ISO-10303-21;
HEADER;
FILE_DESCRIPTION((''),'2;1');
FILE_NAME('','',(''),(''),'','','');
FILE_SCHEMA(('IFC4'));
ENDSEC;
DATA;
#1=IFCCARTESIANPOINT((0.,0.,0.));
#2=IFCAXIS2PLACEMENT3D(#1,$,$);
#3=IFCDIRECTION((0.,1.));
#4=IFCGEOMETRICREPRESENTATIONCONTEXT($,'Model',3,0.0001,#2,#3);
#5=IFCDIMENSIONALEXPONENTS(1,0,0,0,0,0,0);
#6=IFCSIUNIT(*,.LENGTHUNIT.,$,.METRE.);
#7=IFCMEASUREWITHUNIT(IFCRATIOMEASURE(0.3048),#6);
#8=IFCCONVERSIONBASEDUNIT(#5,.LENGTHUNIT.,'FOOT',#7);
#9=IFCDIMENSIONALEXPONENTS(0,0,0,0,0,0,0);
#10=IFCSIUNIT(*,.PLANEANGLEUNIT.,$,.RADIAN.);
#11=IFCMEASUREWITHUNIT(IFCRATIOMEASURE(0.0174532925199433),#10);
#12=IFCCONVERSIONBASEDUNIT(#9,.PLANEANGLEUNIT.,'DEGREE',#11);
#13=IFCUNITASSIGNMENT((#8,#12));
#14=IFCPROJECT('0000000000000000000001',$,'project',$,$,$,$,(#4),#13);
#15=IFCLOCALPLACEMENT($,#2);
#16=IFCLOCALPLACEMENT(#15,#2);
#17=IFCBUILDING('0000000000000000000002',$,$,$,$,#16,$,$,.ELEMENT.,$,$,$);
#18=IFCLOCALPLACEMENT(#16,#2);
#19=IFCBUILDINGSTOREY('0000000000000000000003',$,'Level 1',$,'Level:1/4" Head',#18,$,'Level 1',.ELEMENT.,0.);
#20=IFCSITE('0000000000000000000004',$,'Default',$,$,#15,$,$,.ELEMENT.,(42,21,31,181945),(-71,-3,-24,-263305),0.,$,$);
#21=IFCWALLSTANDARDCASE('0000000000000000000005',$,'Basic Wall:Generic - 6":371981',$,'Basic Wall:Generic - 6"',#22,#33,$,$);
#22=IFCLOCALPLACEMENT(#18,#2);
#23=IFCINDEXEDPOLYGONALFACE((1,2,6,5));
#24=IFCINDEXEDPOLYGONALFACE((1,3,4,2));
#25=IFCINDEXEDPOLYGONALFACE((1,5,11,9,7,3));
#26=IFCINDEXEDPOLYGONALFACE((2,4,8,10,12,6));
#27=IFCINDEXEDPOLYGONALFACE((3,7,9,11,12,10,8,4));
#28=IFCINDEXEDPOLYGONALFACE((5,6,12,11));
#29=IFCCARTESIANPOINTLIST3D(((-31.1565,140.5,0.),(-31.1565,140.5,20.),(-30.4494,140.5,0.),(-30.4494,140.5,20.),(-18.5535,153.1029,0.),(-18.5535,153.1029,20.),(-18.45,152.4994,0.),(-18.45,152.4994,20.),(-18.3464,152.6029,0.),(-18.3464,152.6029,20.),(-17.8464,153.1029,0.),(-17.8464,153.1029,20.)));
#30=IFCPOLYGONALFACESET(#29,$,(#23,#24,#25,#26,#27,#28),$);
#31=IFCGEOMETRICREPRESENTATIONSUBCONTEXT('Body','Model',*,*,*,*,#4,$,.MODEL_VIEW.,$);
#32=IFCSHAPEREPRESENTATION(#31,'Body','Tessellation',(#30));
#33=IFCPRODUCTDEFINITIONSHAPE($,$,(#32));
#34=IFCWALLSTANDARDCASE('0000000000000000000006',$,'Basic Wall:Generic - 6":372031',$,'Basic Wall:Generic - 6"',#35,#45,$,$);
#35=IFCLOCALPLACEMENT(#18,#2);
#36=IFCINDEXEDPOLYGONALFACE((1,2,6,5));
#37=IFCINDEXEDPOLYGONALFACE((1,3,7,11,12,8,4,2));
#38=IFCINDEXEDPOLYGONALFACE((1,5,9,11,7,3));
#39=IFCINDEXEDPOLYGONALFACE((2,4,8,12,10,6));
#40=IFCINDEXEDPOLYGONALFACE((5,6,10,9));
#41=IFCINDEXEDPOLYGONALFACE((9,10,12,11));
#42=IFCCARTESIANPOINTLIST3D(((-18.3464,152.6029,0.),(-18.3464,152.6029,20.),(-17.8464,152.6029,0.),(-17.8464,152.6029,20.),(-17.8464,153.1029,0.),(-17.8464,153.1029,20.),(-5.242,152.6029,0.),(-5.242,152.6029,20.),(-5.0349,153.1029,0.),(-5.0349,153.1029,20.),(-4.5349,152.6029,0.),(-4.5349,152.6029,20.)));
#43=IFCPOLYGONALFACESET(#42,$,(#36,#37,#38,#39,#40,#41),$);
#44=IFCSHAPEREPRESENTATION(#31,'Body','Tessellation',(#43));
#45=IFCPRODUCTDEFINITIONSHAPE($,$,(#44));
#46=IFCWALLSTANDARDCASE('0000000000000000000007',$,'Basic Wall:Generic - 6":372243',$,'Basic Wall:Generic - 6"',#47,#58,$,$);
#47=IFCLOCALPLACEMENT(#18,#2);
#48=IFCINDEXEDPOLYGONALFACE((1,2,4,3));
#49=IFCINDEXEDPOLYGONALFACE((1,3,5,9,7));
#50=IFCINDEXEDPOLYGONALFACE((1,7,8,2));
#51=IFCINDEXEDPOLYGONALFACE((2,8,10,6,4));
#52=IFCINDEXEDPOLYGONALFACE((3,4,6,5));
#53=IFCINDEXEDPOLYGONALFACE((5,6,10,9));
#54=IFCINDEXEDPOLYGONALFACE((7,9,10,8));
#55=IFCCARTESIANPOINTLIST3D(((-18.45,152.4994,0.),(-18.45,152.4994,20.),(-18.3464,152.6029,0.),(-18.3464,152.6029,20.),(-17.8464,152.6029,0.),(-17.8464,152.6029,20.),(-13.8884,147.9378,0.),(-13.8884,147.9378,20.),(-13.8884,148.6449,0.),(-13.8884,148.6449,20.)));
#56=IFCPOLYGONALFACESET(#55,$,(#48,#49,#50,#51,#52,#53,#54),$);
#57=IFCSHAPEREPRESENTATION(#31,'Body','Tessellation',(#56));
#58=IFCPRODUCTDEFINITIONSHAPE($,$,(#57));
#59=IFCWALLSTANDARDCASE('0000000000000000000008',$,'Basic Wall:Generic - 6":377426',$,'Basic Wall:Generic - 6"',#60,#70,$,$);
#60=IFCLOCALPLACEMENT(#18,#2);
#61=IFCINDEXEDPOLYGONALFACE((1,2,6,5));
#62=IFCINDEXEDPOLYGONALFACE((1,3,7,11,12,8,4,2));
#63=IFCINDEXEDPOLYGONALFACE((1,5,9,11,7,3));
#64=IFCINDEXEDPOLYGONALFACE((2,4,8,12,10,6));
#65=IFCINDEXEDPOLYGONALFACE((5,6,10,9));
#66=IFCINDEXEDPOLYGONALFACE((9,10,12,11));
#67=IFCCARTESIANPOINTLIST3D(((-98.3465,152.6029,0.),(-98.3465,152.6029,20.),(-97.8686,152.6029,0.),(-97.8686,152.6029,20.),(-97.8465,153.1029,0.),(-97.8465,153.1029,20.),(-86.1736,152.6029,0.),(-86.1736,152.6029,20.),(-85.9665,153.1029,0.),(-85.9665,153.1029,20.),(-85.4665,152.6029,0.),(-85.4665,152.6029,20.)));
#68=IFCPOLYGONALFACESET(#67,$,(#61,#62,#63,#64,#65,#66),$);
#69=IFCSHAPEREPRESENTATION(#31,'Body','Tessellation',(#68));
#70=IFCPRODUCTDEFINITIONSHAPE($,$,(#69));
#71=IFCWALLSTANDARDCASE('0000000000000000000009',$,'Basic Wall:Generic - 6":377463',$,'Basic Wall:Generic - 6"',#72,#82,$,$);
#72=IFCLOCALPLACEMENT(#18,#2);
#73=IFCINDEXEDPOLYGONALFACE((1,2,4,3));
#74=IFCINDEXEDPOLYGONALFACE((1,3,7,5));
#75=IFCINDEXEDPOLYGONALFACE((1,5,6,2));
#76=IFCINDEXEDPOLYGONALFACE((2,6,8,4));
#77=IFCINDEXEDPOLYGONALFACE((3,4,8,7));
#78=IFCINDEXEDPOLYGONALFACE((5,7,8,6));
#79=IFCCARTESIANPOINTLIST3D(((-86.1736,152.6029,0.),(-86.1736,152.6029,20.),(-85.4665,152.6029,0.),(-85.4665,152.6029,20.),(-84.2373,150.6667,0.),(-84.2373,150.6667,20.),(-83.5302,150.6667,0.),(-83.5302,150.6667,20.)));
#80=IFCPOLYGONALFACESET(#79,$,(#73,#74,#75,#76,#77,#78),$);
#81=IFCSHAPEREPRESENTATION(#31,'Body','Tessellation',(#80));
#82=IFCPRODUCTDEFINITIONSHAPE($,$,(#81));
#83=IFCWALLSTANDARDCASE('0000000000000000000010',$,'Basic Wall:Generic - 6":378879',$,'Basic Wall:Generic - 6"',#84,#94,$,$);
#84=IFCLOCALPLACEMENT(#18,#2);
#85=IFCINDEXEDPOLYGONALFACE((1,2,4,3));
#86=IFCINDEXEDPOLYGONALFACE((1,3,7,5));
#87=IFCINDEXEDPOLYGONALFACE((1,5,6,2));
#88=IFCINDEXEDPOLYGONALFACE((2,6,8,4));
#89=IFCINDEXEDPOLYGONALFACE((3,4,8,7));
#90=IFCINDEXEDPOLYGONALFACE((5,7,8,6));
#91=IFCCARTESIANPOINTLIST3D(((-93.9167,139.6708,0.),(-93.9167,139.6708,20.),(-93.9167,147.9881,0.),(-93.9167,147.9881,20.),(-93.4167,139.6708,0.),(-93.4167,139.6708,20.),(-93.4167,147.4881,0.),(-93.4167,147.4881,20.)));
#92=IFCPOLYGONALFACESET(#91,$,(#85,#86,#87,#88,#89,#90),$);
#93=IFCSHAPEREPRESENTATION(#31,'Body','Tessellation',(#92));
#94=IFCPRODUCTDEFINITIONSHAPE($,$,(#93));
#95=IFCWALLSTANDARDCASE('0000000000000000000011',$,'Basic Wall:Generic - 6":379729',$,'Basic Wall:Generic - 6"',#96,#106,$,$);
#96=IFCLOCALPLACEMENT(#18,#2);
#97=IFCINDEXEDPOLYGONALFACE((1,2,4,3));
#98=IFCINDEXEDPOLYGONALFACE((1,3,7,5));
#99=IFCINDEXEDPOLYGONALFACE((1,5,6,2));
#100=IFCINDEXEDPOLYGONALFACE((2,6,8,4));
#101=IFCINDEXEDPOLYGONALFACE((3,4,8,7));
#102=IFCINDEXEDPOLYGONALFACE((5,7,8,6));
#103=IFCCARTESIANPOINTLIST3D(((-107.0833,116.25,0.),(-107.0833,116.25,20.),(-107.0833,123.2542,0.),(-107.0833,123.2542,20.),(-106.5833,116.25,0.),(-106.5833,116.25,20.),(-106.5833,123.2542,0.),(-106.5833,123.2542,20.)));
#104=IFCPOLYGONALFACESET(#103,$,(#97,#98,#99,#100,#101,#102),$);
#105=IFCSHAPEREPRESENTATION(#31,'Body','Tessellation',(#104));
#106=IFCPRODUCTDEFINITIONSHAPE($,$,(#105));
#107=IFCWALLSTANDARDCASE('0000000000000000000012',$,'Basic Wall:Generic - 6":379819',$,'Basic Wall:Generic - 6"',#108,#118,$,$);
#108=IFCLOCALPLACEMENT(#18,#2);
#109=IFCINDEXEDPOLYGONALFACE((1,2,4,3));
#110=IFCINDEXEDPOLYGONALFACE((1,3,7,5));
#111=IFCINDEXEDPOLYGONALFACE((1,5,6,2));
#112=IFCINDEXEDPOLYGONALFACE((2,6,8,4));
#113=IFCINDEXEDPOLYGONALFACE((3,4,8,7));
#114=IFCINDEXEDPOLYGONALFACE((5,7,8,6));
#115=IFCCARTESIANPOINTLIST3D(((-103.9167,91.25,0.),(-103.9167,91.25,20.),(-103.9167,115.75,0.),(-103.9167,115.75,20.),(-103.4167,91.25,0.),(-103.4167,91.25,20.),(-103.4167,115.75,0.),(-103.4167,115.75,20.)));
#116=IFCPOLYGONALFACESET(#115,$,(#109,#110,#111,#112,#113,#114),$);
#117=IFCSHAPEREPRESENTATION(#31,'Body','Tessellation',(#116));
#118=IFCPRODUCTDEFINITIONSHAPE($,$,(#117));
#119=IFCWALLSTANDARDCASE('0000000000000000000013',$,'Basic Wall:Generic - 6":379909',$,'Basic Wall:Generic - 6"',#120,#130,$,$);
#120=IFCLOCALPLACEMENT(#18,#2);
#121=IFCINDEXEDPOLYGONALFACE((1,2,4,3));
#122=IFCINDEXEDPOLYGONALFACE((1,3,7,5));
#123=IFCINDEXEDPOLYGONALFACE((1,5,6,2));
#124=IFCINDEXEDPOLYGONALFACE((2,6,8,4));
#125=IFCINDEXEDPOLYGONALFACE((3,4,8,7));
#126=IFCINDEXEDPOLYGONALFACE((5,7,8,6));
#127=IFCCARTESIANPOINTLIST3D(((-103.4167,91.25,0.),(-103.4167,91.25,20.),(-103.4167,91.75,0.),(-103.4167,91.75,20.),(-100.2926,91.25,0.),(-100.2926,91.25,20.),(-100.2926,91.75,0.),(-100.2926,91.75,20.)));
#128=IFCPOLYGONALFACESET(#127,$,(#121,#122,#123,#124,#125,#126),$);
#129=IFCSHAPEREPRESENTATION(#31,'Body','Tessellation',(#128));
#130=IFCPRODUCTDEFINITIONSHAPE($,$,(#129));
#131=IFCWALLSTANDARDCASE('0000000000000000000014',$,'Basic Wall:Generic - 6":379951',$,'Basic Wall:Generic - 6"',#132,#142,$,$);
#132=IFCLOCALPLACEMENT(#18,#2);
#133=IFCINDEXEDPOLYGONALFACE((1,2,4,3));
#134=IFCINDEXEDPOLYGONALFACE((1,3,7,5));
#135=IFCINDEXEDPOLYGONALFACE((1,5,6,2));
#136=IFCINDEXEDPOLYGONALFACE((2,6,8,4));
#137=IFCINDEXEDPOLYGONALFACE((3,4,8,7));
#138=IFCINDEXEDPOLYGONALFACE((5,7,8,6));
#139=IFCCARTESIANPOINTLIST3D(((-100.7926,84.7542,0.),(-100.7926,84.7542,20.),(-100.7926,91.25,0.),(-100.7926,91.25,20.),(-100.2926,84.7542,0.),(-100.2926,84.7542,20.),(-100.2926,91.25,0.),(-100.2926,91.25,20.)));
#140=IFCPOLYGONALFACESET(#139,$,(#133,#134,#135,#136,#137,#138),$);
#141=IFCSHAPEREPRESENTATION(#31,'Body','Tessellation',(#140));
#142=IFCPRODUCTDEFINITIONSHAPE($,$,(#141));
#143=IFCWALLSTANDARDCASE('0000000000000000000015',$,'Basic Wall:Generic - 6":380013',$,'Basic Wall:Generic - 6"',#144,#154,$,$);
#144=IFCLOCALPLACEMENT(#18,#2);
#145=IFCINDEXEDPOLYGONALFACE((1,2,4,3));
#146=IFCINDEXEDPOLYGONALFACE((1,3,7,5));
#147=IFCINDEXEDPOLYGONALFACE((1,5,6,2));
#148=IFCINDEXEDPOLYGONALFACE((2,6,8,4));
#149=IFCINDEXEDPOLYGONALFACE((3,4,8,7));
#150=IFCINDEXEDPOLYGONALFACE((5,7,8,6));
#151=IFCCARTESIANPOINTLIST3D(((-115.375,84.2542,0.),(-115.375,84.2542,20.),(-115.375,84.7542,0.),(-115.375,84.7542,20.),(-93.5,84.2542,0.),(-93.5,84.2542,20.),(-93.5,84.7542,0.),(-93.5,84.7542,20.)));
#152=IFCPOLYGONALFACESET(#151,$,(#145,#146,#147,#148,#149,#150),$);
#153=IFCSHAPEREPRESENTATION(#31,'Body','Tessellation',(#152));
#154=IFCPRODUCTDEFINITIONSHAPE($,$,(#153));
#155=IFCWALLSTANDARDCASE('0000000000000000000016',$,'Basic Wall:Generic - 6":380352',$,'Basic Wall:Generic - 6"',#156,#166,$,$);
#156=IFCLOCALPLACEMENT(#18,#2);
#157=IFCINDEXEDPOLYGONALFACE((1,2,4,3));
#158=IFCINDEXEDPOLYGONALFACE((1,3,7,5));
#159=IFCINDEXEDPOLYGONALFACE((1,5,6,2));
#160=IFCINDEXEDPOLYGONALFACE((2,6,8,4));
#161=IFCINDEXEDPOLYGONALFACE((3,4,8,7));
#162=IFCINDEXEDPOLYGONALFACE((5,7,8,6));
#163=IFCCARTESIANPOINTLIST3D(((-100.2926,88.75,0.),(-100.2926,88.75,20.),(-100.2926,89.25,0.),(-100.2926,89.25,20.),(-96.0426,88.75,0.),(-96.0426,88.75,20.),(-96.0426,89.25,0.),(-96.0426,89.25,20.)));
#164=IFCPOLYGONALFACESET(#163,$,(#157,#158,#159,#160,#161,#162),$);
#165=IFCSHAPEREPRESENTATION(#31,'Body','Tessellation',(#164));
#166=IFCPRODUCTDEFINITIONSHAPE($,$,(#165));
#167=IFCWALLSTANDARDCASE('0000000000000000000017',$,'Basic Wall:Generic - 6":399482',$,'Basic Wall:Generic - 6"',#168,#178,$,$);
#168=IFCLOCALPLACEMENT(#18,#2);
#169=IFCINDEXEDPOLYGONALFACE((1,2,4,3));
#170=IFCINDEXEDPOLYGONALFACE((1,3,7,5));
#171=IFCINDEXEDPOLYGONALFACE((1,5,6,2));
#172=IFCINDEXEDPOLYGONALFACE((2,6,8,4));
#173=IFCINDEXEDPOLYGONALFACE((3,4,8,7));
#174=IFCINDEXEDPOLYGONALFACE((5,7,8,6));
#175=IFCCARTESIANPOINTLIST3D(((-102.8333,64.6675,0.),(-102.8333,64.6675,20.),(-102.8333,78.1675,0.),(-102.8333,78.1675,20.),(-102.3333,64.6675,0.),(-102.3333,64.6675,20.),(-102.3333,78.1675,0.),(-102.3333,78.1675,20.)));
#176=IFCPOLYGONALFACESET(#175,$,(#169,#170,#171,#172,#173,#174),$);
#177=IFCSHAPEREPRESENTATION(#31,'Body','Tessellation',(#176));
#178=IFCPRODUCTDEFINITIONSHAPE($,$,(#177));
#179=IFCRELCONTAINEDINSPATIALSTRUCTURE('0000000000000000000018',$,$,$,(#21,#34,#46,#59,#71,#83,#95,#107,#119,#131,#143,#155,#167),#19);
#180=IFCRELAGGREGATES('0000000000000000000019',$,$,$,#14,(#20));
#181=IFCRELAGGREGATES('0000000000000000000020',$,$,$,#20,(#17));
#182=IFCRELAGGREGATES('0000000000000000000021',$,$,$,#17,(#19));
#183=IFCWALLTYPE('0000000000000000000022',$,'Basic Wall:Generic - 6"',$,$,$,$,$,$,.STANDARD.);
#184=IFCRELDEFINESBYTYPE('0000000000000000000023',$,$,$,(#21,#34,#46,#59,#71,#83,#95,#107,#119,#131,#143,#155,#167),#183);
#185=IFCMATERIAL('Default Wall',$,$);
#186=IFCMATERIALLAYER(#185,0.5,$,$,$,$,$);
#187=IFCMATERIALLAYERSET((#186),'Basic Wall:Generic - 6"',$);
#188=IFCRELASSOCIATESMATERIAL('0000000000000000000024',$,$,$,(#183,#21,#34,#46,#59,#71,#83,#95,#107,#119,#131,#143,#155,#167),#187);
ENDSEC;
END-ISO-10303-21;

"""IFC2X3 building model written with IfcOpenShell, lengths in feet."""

from ifc_helpers import new_model, entity, si_unit, converted_unit, direction, frame, frame_2d, origin, place, context, subcontext, project, spatial, polyline, rectangle, outline, extrude, material, layer, layer_set, layer_usage, type_object, element, save


model = new_model("IFC2X3")

# Units and contexts
model_context = context("Model", 3, precision=0.0001, world=origin(), true_north=direction((0.0, 1.0)))
body_context = subcontext(model_context, "Body", "Model", "MODEL_VIEW")
ifc_project = project(units=[converted_unit("LENGTHUNIT", "FOOT", entity("IfcRatioMeasure", 0.3048), si_unit("LENGTHUNIT", "METRE"), dimensions=[1, 0, 0, 0, 0, 0, 0]), converted_unit("PLANEANGLEUNIT", "DEGREE", entity("IfcRatioMeasure", 0.0174532925199433), si_unit("PLANEANGLEUNIT", "RADIAN"), dimensions=[0, 0, 0, 0, 0, 0, 0])], contexts=[model_context])

# Site, building, storey
site_placement = place(None, origin())
site = spatial("IfcSite", under=ifc_project, at=site_placement, Name="Default", CompositionType="ELEMENT", RefLatitude=(42, 21, 31, 181945), RefLongitude=(-71, -3, -24, -263305), RefElevation=0.0)
building_placement = place(site_placement, origin())
building = spatial("IfcBuilding", under=site, at=building_placement, CompositionType="ELEMENT")
storey_placement = place(building_placement, origin())
storey = spatial("IfcBuildingStorey", under=building, at=storey_placement, Name="Level 1", ObjectType="Level:1/4\" Head", LongName="Level 1", CompositionType="ELEMENT", Elevation=0.0)

# Walls
ifc_material_1 = material(Name="Default Wall")
ifc_layer_1 = layer(ifc_material_1, 0.5)
ifc_layer_set_1 = layer_set([ifc_layer_1], Name="Basic Wall:Generic - 6\"")
wall_type_1 = type_object("IfcWallType", Name="Basic Wall:Generic - 6\"", PredefinedType="STANDARD", material=ifc_layer_set_1)
ifc_layer_usage_1 = layer_usage(ifc_layer_set_1, "AXIS2", "NEGATIVE", 0.25)
wall_1_placement = place(storey_placement, frame((-30.9797, 140.3232, 0.0), z_axis=(0.0, 0.0, 1.0), x_axis=(0.707107, 0.707107, 0.0)))
element("IfcWallStandardCase", 1, at=wall_1_placement, inside=storey, type_object=wall_type_1, material=ifc_layer_usage_1, Name="Basic Wall:Generic - 6\":371981", ObjectType="Basic Wall:Generic - 6\"", context=body_context, shape_type="SweptSolid", body=[
    extrude(outline(polyline([(18.3233, -0.25), (17.8233, 0.25), (0.0, 0.25), (0.5, -0.25), (17.4697, -0.25), (17.6162, -0.25), (18.3233, -0.25)])), origin(), (0.0, 0.0, 1.0), 20.0),
])
ifc_layer_usage_2 = layer_usage(ifc_layer_set_1, "AXIS2", "NEGATIVE", 0.25)
wall_2_placement = place(storey_placement, frame((-18.3464, 152.8529, 0.0)))
element("IfcWallStandardCase", 2, at=wall_2_placement, inside=storey, type_object=wall_type_1, material=ifc_layer_usage_2, Name="Basic Wall:Generic - 6\":372031", ObjectType="Basic Wall:Generic - 6\"", context=body_context, shape_type="SweptSolid", body=[
    extrude(outline(polyline([(13.8116, -0.25), (13.3116, 0.25), (0.5, 0.25), (0.0, -0.25), (0.5, -0.25), (13.1044, -0.25), (13.8116, -0.25)])), origin(), (0.0, 0.0, 1.0), 20.0),
])
ifc_layer_usage_3 = layer_usage(ifc_layer_set_1, "AXIS2", "NEGATIVE", 0.25)
wall_3_placement = place(storey_placement, frame((-18.2732, 152.6762, 0.0), z_axis=(0.0, 0.0, 1.0), x_axis=(0.707107, -0.707107, 0.0)))
element("IfcWallStandardCase", 3, at=wall_3_placement, inside=storey, type_object=wall_type_1, material=ifc_layer_usage_3, Name="Basic Wall:Generic - 6\":372243", ObjectType="Basic Wall:Generic - 6\"", context=body_context, shape_type="SweptSolid", body=[
    extrude(outline(polyline([(6.451, -0.25), (5.951, 0.25), (0.3536, 0.25), (0.0, -0.1036), (0.0, -0.25), (6.451, -0.25)])), origin(), (0.0, 0.0, 1.0), 20.0),
])
ifc_layer_usage_4 = layer_usage(ifc_layer_set_1, "AXIS2", "NEGATIVE", 0.25)
wall_4_placement = place(storey_placement, frame((-98.3465, 152.8529, 0.0)))
element("IfcWallStandardCase", 4, at=wall_4_placement, inside=storey, type_object=wall_type_1, material=ifc_layer_usage_4, Name="Basic Wall:Generic - 6\":377426", ObjectType="Basic Wall:Generic - 6\"", context=body_context, shape_type="SweptSolid", body=[
    extrude(outline(polyline([(12.88, -0.25), (12.38, 0.25), (0.5, 0.25), (0.0, -0.25), (0.4779, -0.25), (12.1729, -0.25), (12.88, -0.25)])), origin(), (0.0, 0.0, 1.0), 20.0),
])
ifc_layer_usage_5 = layer_usage(ifc_layer_set_1, "AXIS2", "NEGATIVE", 0.25)
wall_5_placement = place(storey_placement, frame((-85.9968, 152.7797, 0.0), z_axis=(0.0, 0.0, 1.0), x_axis=(0.707107, -0.707107, 0.0)))
element("IfcWallStandardCase", 5, at=wall_5_placement, inside=storey, type_object=wall_type_1, material=ifc_layer_usage_5, Name="Basic Wall:Generic - 6\":377463", ObjectType="Basic Wall:Generic - 6\"", context=body_context, shape_type="SweptSolid", body=[
    extrude(outline(polyline([(2.7383, -0.25), (3.2383, 0.25), (0.5, 0.25), (0.0, -0.25), (2.7383, -0.25)])), origin(), (0.0, 0.0, 1.0), 20.0),
])
ifc_layer_usage_6 = layer_usage(ifc_layer_set_1, "AXIS2", "NEGATIVE", 0.25)
wall_6_placement = place(storey_placement, frame((-93.6667, 147.9881, 0.0), z_axis=(0.0, 0.0, 1.0), x_axis=(0.0, -1.0, 0.0)))
element("IfcWallStandardCase", 6, at=wall_6_placement, inside=storey, type_object=wall_type_1, material=ifc_layer_usage_6, Name="Basic Wall:Generic - 6\":378879", ObjectType="Basic Wall:Generic - 6\"", context=body_context, shape_type="SweptSolid", body=[
    extrude(outline(polyline([(8.3173, -0.25), (8.3173, 0.25), (0.5, 0.25), (0.0, -0.25), (8.3173, -0.25)])), origin(), (0.0, 0.0, 1.0), 20.0),
])
ifc_layer_usage_7 = layer_usage(ifc_layer_set_1, "AXIS2", "NEGATIVE", 0.25)
wall_7_placement = place(storey_placement, frame((-106.8333, 123.2542, 0.0), z_axis=(0.0, 0.0, 1.0), x_axis=(0.0, -1.0, 0.0)))
element("IfcWallStandardCase", 7, at=wall_7_placement, inside=storey, type_object=wall_type_1, material=ifc_layer_usage_7, Name="Basic Wall:Generic - 6\":379729", ObjectType="Basic Wall:Generic - 6\"", context=body_context, shape_type="SweptSolid", body=[
    extrude(rectangle(XDim=7.0042, YDim=0.5, at=frame_2d((3.5021, 0.0), x_axis=(-1.0, 0.0))), origin(), (0.0, 0.0, 1.0), 20.0),
])
ifc_layer_usage_8 = layer_usage(ifc_layer_set_1, "AXIS2", "NEGATIVE", 0.25)
wall_8_placement = place(storey_placement, frame((-103.6667, 115.75, 0.0), z_axis=(0.0, 0.0, 1.0), x_axis=(0.0, -1.0, 0.0)))
element("IfcWallStandardCase", 8, at=wall_8_placement, inside=storey, type_object=wall_type_1, material=ifc_layer_usage_8, Name="Basic Wall:Generic - 6\":379819", ObjectType="Basic Wall:Generic - 6\"", context=body_context, shape_type="SweptSolid", body=[
    extrude(rectangle(XDim=24.5, YDim=0.5, at=frame_2d((12.25, 0.0), x_axis=(-1.0, 0.0))), origin(), (0.0, 0.0, 1.0), 20.0),
])
ifc_layer_usage_9 = layer_usage(ifc_layer_set_1, "AXIS2", "NEGATIVE", 0.25)
wall_9_placement = place(storey_placement, frame((-103.4167, 91.5, 0.0)))
element("IfcWallStandardCase", 9, at=wall_9_placement, inside=storey, type_object=wall_type_1, material=ifc_layer_usage_9, Name="Basic Wall:Generic - 6\":379909", ObjectType="Basic Wall:Generic - 6\"", context=body_context, shape_type="SweptSolid", body=[
    extrude(rectangle(XDim=3.1241, YDim=0.5, at=frame_2d((1.562, 0.0), x_axis=(-1.0, 0.0))), origin(), (0.0, 0.0, 1.0), 20.0),
])
ifc_layer_usage_10 = layer_usage(ifc_layer_set_1, "AXIS2", "NEGATIVE", 0.25)
wall_10_placement = place(storey_placement, frame((-100.5426, 91.25, 0.0), z_axis=(0.0, 0.0, 1.0), x_axis=(0.0, -1.0, 0.0)))
element("IfcWallStandardCase", 10, at=wall_10_placement, inside=storey, type_object=wall_type_1, material=ifc_layer_usage_10, Name="Basic Wall:Generic - 6\":379951", ObjectType="Basic Wall:Generic - 6\"", context=body_context, shape_type="SweptSolid", body=[
    extrude(rectangle(XDim=6.4958, YDim=0.5, at=frame_2d((3.2479, 0.0), x_axis=(-1.0, 0.0))), origin(), (0.0, 0.0, 1.0), 20.0),
])
ifc_layer_usage_11 = layer_usage(ifc_layer_set_1, "AXIS2", "NEGATIVE", 0.25)
wall_11_placement = place(storey_placement, frame((-93.5, 84.5042, 0.0), z_axis=(0.0, 0.0, 1.0), x_axis=(-1.0, 0.0, 0.0)))
element("IfcWallStandardCase", 11, at=wall_11_placement, inside=storey, type_object=wall_type_1, material=ifc_layer_usage_11, Name="Basic Wall:Generic - 6\":380013", ObjectType="Basic Wall:Generic - 6\"", context=body_context, shape_type="SweptSolid", body=[
    extrude(rectangle(XDim=21.875, YDim=0.5, at=frame_2d((10.9375, 0.0), x_axis=(-1.0, 0.0))), origin(), (0.0, 0.0, 1.0), 20.0),
])
ifc_layer_usage_12 = layer_usage(ifc_layer_set_1, "AXIS2", "NEGATIVE", 0.25)
wall_12_placement = place(storey_placement, frame((-100.2926, 89.0, 0.0)))
element("IfcWallStandardCase", 12, at=wall_12_placement, inside=storey, type_object=wall_type_1, material=ifc_layer_usage_12, Name="Basic Wall:Generic - 6\":380352", ObjectType="Basic Wall:Generic - 6\"", context=body_context, shape_type="SweptSolid", body=[
    extrude(rectangle(XDim=4.25, YDim=0.5, at=frame_2d((2.125, 0.0), x_axis=(-1.0, 0.0))), origin(), (0.0, 0.0, 1.0), 20.0),
])
ifc_layer_usage_13 = layer_usage(ifc_layer_set_1, "AXIS2", "NEGATIVE", 0.25)
wall_13_placement = place(storey_placement, frame((-102.5833, 78.1675, 0.0), z_axis=(0.0, 0.0, 1.0), x_axis=(0.0, -1.0, 0.0)))
element("IfcWallStandardCase", 13, at=wall_13_placement, inside=storey, type_object=wall_type_1, material=ifc_layer_usage_13, Name="Basic Wall:Generic - 6\":399482", ObjectType="Basic Wall:Generic - 6\"", context=body_context, shape_type="SweptSolid", body=[
    extrude(rectangle(XDim=13.5, YDim=0.5, at=frame_2d((6.75, 0.0), x_axis=(-1.0, 0.0))), origin(), (0.0, 0.0, 1.0), 20.0),
])

save(model, "model.ifc")
